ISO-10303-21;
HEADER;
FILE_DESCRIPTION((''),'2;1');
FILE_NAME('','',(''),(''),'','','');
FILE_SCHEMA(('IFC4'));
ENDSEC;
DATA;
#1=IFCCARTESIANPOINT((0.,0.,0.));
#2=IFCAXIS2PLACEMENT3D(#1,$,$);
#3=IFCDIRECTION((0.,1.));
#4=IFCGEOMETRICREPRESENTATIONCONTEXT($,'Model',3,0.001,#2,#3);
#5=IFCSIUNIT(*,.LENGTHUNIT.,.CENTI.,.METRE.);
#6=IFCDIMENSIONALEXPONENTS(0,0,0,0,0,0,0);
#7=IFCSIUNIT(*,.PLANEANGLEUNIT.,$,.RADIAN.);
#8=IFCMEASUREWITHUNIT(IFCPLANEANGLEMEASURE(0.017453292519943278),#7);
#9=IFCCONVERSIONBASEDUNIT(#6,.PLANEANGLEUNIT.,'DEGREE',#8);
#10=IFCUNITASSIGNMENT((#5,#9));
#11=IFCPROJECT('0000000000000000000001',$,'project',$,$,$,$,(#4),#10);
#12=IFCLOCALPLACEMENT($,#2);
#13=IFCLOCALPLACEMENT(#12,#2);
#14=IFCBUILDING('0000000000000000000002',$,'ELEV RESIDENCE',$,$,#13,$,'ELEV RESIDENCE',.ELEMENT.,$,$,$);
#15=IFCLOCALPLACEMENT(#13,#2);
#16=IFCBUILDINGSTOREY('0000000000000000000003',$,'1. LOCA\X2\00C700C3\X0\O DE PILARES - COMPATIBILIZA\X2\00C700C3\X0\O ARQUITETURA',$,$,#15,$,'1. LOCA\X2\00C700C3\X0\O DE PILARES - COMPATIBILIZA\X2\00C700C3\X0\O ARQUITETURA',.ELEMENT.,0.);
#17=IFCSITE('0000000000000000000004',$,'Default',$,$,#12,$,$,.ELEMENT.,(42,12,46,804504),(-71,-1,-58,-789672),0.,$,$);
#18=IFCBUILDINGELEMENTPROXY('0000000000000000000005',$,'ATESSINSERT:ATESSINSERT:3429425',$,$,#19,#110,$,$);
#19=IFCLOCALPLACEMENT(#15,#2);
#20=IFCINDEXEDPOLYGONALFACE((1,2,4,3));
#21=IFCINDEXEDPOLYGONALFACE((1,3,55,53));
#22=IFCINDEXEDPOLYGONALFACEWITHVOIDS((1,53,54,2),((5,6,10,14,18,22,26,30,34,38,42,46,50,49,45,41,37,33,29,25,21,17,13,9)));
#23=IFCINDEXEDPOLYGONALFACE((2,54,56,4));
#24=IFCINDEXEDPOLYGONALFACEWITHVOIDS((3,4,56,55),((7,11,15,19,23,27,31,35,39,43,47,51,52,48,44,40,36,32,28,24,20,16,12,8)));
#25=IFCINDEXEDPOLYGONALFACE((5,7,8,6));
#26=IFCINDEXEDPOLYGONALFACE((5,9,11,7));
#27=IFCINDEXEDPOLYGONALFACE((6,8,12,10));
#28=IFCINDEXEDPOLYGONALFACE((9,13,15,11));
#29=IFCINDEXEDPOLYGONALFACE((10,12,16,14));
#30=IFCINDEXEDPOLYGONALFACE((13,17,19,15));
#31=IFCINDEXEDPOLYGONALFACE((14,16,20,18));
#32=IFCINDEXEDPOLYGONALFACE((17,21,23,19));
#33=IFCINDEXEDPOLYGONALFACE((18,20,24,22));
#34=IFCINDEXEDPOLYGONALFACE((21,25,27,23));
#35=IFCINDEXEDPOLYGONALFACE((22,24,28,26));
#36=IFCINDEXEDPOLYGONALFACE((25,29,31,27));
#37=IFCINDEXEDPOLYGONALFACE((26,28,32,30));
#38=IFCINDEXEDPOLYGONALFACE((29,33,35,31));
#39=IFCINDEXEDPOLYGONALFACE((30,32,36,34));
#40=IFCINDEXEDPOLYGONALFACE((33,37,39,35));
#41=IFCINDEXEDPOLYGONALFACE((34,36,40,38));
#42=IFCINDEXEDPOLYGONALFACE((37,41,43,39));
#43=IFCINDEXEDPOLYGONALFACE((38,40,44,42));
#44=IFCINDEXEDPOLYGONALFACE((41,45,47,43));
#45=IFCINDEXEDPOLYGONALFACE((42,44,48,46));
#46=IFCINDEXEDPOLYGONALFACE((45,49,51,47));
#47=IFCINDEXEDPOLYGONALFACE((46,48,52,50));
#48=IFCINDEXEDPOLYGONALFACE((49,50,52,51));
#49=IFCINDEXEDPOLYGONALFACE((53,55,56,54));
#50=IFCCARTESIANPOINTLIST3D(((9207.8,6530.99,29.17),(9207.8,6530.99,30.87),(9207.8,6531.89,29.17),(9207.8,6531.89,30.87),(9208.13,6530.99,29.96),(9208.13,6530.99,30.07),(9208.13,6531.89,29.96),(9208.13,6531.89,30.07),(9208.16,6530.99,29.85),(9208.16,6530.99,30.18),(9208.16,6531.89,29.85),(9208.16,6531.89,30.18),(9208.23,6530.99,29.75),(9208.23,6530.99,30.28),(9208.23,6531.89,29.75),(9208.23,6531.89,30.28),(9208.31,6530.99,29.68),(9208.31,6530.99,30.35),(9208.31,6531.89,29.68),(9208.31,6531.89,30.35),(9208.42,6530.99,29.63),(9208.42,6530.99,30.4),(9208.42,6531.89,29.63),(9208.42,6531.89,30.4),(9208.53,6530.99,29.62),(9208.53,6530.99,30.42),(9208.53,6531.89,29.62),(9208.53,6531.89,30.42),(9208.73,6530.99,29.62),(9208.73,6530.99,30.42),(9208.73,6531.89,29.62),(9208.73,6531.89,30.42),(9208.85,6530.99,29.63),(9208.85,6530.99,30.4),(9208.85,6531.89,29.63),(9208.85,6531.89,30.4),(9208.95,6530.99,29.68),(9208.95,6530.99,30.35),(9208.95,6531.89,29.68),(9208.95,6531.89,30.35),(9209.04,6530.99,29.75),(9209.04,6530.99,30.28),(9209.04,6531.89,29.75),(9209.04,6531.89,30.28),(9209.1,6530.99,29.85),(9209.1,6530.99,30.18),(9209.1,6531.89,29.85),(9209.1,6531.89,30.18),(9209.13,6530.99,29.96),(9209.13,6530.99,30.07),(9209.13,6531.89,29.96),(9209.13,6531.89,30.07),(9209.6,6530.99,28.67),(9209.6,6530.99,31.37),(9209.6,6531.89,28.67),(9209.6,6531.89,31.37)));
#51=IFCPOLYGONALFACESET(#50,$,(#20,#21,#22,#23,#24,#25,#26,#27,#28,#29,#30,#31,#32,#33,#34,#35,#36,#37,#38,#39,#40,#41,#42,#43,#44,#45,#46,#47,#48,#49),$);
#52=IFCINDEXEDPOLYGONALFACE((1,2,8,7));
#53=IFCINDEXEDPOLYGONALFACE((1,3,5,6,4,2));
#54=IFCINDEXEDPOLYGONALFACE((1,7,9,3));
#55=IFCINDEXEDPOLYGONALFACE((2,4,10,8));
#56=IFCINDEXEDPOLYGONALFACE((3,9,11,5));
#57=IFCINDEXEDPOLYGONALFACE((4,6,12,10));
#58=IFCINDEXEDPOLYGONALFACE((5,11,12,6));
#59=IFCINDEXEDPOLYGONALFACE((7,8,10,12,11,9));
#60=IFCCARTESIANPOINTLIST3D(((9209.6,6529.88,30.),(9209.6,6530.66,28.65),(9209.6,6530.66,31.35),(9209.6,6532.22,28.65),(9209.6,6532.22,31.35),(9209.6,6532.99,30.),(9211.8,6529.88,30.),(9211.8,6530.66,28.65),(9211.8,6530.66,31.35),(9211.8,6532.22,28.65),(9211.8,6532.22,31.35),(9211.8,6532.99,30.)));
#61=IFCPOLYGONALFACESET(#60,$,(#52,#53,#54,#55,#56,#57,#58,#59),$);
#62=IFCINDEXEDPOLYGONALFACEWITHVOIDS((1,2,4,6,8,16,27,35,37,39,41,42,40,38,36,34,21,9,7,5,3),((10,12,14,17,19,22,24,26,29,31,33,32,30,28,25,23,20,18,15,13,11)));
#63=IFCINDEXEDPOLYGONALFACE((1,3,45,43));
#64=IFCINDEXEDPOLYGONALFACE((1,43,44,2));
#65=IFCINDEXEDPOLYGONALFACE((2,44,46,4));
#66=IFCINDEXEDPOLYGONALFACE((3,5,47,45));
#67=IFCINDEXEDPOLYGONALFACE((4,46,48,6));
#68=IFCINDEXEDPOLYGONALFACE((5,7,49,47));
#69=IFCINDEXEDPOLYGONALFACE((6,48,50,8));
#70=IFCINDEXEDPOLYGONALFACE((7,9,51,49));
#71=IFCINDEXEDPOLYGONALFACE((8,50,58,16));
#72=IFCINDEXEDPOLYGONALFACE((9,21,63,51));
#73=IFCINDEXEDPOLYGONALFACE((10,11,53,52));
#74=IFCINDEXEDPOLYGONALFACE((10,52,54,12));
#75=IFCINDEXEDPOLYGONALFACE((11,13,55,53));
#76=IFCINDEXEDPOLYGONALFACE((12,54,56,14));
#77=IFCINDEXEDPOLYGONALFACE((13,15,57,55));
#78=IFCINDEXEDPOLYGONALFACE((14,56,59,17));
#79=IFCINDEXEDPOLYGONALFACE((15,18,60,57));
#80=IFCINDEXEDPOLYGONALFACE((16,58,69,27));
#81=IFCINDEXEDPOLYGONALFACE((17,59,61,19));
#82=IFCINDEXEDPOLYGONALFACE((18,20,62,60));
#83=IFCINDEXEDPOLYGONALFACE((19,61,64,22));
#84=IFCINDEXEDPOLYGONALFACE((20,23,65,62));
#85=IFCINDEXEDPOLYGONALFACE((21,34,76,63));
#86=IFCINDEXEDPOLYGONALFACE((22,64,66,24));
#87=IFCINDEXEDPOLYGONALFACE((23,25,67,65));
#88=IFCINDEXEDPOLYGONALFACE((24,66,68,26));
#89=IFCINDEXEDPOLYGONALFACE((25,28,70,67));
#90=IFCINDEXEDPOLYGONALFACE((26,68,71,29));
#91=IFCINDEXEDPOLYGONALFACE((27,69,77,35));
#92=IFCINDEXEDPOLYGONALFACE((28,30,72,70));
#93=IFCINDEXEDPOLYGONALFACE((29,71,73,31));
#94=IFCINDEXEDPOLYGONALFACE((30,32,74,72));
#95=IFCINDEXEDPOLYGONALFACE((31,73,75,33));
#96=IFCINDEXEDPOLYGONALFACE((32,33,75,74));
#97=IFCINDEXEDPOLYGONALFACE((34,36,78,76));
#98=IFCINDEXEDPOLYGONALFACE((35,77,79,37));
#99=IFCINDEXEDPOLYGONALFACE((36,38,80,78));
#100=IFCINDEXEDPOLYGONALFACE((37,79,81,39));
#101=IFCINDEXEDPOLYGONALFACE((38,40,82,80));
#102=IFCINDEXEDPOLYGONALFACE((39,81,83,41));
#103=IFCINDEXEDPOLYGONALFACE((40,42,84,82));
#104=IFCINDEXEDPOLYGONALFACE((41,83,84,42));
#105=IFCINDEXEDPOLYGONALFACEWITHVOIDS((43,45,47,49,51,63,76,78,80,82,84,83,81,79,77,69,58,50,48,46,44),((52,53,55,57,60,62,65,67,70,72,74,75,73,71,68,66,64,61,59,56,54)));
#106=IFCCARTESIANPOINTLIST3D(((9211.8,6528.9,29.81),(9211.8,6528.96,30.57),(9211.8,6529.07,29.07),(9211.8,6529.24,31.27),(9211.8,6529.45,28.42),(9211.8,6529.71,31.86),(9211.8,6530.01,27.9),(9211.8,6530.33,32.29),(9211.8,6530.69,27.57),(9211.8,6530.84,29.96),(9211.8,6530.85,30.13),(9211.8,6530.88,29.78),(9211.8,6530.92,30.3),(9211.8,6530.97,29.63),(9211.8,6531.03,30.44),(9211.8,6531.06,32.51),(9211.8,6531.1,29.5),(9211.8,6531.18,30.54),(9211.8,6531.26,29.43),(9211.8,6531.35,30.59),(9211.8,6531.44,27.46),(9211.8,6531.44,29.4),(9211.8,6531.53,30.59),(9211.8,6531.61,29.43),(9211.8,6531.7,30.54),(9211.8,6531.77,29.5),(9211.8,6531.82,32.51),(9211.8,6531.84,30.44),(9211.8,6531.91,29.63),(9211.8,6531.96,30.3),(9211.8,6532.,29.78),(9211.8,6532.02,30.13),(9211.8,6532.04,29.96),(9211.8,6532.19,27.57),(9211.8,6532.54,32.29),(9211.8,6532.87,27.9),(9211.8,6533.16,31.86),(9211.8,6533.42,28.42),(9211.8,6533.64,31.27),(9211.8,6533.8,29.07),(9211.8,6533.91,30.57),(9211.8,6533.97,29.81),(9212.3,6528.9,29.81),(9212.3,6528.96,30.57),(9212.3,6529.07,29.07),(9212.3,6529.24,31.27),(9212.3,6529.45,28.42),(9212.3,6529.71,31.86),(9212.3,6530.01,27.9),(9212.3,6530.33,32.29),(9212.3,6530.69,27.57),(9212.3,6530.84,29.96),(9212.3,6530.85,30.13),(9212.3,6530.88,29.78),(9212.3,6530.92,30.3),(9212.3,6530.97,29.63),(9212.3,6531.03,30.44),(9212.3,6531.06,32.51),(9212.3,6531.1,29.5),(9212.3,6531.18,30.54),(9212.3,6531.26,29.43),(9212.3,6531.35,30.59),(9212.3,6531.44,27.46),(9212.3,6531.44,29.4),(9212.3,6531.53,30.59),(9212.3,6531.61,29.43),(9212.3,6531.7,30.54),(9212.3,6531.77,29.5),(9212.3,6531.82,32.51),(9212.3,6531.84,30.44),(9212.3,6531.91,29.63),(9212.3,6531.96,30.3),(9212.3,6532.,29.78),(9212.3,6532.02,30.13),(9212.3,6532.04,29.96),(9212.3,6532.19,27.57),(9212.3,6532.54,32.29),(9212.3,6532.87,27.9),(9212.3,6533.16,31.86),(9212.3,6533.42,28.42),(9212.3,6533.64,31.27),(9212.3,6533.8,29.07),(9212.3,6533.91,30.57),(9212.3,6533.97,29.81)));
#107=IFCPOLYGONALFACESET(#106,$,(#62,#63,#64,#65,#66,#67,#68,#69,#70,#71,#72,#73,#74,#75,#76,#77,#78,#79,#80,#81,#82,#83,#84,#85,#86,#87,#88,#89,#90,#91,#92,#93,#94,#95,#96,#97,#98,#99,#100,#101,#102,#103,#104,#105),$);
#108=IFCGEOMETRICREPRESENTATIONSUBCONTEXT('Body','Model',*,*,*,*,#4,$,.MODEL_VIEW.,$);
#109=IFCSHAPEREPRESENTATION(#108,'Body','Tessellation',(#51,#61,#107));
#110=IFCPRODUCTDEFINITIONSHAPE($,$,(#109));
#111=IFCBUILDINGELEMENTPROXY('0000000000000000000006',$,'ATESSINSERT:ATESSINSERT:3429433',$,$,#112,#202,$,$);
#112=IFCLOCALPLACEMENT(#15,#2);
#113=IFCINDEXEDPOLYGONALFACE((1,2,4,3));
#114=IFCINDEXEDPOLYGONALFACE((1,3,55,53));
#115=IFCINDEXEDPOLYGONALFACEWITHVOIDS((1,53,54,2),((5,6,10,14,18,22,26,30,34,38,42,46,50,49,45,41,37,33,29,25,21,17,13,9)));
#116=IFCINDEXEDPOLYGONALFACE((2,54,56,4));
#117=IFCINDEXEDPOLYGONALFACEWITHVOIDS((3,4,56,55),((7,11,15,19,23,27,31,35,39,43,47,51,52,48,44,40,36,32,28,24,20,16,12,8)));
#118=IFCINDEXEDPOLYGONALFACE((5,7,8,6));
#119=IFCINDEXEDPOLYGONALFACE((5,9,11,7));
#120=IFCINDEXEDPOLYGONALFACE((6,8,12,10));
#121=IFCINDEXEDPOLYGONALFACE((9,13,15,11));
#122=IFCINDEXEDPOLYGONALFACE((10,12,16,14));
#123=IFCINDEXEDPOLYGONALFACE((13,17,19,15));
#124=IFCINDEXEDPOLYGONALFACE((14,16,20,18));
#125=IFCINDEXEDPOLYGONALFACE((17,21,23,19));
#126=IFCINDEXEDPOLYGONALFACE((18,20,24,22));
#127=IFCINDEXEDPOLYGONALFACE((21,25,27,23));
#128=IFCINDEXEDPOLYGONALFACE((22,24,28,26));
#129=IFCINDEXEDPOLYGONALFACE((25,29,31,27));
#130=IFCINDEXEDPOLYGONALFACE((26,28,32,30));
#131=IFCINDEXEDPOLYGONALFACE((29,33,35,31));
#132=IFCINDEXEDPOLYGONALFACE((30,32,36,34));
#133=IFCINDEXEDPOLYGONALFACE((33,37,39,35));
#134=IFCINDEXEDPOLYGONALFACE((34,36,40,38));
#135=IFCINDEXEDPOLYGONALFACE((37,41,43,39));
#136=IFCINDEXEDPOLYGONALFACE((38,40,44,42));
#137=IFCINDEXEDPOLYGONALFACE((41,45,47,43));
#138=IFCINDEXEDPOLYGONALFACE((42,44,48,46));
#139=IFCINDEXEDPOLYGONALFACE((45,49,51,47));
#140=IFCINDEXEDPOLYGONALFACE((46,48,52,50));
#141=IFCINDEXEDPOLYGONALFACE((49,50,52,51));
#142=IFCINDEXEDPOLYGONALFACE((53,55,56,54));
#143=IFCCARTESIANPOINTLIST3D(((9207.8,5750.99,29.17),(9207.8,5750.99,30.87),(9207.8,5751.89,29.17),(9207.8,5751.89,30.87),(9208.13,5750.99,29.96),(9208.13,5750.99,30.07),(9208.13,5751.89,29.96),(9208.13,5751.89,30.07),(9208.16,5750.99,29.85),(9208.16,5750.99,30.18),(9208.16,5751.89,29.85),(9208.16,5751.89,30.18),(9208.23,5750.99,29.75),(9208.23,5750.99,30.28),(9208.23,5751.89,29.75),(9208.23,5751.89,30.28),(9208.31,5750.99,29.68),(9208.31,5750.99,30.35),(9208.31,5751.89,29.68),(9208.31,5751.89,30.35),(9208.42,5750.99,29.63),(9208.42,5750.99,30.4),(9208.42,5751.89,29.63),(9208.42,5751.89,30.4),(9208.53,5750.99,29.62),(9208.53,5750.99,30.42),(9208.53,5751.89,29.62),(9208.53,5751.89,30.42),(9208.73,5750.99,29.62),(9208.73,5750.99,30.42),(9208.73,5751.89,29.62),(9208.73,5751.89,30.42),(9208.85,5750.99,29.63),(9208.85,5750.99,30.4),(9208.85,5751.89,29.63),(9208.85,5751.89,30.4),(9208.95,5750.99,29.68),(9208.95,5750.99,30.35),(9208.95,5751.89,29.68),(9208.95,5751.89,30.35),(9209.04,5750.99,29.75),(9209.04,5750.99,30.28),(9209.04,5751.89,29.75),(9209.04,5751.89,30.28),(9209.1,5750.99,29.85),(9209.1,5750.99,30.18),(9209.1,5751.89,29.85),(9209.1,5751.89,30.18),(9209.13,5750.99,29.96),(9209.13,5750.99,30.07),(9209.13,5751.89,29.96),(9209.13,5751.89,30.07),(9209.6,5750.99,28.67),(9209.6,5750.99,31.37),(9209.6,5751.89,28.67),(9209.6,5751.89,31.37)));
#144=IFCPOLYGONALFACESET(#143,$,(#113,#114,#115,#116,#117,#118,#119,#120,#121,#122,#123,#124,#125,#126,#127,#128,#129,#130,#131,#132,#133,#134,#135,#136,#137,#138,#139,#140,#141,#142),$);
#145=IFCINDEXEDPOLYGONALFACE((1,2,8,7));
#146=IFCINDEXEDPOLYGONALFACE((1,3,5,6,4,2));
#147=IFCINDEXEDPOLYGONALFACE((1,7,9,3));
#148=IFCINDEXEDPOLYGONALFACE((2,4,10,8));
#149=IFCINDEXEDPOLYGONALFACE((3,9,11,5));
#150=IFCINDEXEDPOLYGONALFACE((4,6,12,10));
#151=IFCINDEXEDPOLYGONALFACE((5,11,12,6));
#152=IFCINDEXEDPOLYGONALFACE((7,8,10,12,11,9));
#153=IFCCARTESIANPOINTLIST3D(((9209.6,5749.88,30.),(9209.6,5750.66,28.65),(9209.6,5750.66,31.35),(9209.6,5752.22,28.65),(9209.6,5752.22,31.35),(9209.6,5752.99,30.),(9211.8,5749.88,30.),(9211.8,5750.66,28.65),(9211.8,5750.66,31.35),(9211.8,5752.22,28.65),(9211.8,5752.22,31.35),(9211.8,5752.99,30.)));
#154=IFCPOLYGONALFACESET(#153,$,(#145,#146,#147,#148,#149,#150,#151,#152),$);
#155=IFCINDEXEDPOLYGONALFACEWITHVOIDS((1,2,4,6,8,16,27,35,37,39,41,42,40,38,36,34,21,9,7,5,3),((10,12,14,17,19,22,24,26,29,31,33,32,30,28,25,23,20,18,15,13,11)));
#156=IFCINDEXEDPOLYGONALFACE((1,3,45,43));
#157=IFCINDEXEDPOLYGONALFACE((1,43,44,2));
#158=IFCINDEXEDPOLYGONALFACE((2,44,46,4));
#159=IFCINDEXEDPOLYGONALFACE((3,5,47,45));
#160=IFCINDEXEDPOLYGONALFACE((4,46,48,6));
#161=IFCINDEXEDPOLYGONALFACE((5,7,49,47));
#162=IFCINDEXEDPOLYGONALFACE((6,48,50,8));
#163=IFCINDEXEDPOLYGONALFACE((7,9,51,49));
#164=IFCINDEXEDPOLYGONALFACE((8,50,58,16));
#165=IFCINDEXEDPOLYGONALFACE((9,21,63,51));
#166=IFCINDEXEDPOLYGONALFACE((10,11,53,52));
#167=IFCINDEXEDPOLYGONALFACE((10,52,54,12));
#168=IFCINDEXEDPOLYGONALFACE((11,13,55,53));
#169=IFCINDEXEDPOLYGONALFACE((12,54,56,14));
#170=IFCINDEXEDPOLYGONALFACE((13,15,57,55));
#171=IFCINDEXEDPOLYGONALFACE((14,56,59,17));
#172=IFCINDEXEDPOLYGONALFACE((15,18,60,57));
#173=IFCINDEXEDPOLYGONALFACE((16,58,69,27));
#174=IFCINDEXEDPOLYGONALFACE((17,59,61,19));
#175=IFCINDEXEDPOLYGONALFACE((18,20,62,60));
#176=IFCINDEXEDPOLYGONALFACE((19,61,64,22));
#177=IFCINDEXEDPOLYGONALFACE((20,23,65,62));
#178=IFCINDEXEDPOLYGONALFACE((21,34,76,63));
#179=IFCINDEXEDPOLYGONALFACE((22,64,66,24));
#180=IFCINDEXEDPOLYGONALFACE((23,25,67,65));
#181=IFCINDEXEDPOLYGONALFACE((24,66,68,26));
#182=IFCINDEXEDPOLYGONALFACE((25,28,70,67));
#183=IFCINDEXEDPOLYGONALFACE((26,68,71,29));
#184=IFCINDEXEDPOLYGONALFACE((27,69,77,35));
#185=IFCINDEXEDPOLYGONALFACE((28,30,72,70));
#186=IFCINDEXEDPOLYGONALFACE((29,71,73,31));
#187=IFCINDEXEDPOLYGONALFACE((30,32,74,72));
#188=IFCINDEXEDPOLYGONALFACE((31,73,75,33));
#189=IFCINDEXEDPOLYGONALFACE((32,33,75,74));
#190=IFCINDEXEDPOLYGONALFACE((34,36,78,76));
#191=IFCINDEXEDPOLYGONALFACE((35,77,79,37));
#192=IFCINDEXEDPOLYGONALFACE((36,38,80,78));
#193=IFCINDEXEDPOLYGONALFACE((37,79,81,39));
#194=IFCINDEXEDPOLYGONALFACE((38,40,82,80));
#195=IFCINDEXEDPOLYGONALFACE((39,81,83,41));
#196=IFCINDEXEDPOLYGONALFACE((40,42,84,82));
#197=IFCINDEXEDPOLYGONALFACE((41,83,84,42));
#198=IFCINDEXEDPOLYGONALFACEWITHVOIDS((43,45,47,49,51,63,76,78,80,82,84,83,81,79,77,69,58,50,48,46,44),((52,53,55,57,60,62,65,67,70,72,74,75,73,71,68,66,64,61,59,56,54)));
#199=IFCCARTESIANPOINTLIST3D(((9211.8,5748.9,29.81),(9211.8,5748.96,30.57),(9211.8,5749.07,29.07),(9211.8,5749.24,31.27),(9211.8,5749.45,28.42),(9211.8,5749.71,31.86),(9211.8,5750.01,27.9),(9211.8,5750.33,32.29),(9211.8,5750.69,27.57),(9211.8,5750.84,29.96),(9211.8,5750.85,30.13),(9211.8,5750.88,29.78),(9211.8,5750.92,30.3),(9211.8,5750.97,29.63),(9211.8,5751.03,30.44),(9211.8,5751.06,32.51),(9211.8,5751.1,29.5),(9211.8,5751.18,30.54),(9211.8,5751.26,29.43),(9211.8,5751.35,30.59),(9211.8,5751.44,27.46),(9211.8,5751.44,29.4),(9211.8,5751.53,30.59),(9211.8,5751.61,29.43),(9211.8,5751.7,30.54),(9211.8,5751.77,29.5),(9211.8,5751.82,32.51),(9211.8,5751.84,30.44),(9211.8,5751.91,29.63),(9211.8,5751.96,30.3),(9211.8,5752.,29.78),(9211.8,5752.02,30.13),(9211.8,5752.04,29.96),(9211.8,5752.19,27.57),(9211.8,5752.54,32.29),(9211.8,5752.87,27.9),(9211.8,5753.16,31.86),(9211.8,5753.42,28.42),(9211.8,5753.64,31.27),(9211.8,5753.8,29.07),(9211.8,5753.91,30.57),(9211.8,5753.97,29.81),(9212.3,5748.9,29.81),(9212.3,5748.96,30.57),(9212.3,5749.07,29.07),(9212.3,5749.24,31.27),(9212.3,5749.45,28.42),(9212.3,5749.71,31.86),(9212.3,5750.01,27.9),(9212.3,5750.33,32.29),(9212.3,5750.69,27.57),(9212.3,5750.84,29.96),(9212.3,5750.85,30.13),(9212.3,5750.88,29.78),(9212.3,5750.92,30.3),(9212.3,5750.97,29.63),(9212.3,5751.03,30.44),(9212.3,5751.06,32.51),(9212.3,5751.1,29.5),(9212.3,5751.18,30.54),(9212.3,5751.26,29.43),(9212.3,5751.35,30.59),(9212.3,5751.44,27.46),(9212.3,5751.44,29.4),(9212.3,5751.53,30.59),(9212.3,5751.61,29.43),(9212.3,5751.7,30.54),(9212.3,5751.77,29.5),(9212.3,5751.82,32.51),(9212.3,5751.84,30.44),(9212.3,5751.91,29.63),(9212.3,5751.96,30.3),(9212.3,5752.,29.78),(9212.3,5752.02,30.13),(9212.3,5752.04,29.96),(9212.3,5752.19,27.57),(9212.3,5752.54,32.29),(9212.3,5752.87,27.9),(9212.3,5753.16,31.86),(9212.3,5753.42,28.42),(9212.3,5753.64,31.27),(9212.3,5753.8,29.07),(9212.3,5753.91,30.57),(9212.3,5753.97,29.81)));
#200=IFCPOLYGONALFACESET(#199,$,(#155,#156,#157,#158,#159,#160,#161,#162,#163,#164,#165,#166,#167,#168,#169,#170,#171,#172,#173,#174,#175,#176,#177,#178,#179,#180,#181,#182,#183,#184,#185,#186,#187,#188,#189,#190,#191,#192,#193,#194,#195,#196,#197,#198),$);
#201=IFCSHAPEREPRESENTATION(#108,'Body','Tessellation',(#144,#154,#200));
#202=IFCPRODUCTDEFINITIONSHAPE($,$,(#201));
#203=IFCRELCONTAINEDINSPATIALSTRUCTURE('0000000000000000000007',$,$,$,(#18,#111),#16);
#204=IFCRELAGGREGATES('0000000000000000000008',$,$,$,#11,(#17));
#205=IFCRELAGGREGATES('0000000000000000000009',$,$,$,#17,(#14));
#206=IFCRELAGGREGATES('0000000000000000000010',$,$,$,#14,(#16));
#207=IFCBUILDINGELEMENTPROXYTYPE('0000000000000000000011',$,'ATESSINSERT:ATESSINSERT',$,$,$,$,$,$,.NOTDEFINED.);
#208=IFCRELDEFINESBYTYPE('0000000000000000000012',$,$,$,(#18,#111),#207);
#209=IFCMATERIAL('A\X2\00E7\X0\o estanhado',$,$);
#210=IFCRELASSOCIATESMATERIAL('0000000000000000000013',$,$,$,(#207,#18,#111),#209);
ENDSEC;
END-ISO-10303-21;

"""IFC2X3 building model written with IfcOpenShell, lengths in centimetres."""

from ifc_helpers import new_model, entity, si_unit, converted_unit, direction, frame, frame_2d, origin, place, context, subcontext, project, spatial, polyline, circle_curve, parameter, trimmed, segment, composite_curve, hollow_circle, outline, extrude, source, transform, mapped, material, type_object, type_shapes, element, save


model = new_model("IFC2X3")

# Units and contexts
model_context = context("Model", 3, precision=0.001, world=origin(), true_north=direction((0.0, 1.0)))
body_context = subcontext(model_context, "Body", "Model", "MODEL_VIEW")
ifc_project = project(units=[si_unit("LENGTHUNIT", "METRE", prefix="CENTI"), converted_unit("PLANEANGLEUNIT", "DEGREE", entity("IfcPlaneAngleMeasure", 0.017453292519943278), si_unit("PLANEANGLEUNIT", "RADIAN"), dimensions=[0, 0, 0, 0, 0, 0, 0])], contexts=[model_context])

# Site, building, storey
site_placement = place(None, origin())
site = spatial("IfcSite", under=ifc_project, at=site_placement, Name="Default", CompositionType="ELEMENT", RefLatitude=(42, 12, 46, 804504), RefLongitude=(-71, -1, -58, -789672), RefElevation=0.0)
building_placement = place(site_placement, origin())
building = spatial("IfcBuilding", under=site, at=building_placement, Name="ELEV RESIDENCE", LongName="ELEV RESIDENCE", CompositionType="ELEMENT")
storey_placement = place(building_placement, origin())
storey = spatial("IfcBuildingStorey", under=building, at=storey_placement, Name="1. LOCAÇÃO DE PILARES - COMPATIBILIZAÇÃO ARQUITETURA", LongName="1. LOCAÇÃO DE PILARES - COMPATIBILIZAÇÃO ARQUITETURA", CompositionType="ELEMENT", Elevation=0.0)

# Building element proxies
ifc_material_1 = material(Name="Aço estanhado")
building_element_proxy_type_1 = type_object("IfcBuildingElementProxyType", Name="ATESSINSERT:ATESSINSERT", PredefinedType="NOTDEFINED", material=ifc_material_1)
shared_shape_1 = source(origin(), body_context, "Body", "SweptSolid", [
    extrude(outline(polyline([(-1.35, -0.9), (1.35, -0.9), (0.85, 0.9), (-0.85, 0.9), (-1.35, -0.9)]), holes=[composite_curve([segment(trimmed(circle_curve(frame_2d((0.0, 0.17), x_axis=(1.0, 0.0)), 0.4), [parameter(0.0)], [parameter(180.0)], True, "PARAMETER"), False, "CONTINUOUS"), segment(polyline([(0.4, 0.17), (0.4, -0.03)]), True, "CONTINUOUS"), segment(trimmed(circle_curve(frame_2d((0.0, -0.03), x_axis=(1.0, 0.0)), 0.4), [parameter(180.0)], [parameter(0.0)], True, "PARAMETER"), False, "CONTINUOUS"), segment(polyline([(-0.4, -0.03), (-0.4, 0.17)]), True, "CONTINUOUS")], self_intersect=False)]), frame((-1.4, -0.45, 30.02), z_axis=(0.0, 1.0, 0.0), x_axis=(0.0, 0.0, 1.0)), (0.0, 0.0, 1.0), 0.9),
    extrude(outline(polyline([(-0.78, -1.35), (0.78, -1.35), (1.56, 0.0), (0.78, 1.35), (-0.78, 1.35), (-1.56, 0.0), (-0.78, -1.35)])), frame((-4.5, 0.0, 30.0), z_axis=(1.0, 0.0, 0.0), x_axis=(0.0, 0.5, 0.866025)), (0.0, 0.0, 1.0), 2.2),
    extrude(hollow_circle(Radius=2.54, WallThickness=1.94, at=frame_2d((0.0, 0.0), x_axis=(1.0, 0.0))), frame((-5.0, 0.0, 30.0), z_axis=(1.0, 0.0, 0.0), x_axis=(0.0, 0.0, -1.0)), (0.0, 0.0, 1.0), 0.5),
])
type_shapes(building_element_proxy_type_1, [shared_shape_1])
for number, where, z_axis, x_axis, name in (
    (1, (9207.3, 6531.44, 0.0), (0.0, 0.0, 1.0), (-1.0, 0.0, 0.0), "ATESSINSERT:ATESSINSERT:3429425"),
    (2, (9207.3, 5751.44, 0.0), (0.0, 0.0, 1.0), (-1.0, 0.0, 0.0), "ATESSINSERT:ATESSINSERT:3429433"),
):
    element("IfcBuildingElementProxy", number, at=place(storey_placement, frame(where, z_axis=z_axis, x_axis=x_axis)), inside=storey, type_object=building_element_proxy_type_1, material=ifc_material_1, Name=name, context=body_context, shape_type="MappedRepresentation", body=[
        mapped(shared_shape_1, transform((0.0, 0.0, 0.0), scale=1.0)),
    ])

save(model, "model.ifc")
